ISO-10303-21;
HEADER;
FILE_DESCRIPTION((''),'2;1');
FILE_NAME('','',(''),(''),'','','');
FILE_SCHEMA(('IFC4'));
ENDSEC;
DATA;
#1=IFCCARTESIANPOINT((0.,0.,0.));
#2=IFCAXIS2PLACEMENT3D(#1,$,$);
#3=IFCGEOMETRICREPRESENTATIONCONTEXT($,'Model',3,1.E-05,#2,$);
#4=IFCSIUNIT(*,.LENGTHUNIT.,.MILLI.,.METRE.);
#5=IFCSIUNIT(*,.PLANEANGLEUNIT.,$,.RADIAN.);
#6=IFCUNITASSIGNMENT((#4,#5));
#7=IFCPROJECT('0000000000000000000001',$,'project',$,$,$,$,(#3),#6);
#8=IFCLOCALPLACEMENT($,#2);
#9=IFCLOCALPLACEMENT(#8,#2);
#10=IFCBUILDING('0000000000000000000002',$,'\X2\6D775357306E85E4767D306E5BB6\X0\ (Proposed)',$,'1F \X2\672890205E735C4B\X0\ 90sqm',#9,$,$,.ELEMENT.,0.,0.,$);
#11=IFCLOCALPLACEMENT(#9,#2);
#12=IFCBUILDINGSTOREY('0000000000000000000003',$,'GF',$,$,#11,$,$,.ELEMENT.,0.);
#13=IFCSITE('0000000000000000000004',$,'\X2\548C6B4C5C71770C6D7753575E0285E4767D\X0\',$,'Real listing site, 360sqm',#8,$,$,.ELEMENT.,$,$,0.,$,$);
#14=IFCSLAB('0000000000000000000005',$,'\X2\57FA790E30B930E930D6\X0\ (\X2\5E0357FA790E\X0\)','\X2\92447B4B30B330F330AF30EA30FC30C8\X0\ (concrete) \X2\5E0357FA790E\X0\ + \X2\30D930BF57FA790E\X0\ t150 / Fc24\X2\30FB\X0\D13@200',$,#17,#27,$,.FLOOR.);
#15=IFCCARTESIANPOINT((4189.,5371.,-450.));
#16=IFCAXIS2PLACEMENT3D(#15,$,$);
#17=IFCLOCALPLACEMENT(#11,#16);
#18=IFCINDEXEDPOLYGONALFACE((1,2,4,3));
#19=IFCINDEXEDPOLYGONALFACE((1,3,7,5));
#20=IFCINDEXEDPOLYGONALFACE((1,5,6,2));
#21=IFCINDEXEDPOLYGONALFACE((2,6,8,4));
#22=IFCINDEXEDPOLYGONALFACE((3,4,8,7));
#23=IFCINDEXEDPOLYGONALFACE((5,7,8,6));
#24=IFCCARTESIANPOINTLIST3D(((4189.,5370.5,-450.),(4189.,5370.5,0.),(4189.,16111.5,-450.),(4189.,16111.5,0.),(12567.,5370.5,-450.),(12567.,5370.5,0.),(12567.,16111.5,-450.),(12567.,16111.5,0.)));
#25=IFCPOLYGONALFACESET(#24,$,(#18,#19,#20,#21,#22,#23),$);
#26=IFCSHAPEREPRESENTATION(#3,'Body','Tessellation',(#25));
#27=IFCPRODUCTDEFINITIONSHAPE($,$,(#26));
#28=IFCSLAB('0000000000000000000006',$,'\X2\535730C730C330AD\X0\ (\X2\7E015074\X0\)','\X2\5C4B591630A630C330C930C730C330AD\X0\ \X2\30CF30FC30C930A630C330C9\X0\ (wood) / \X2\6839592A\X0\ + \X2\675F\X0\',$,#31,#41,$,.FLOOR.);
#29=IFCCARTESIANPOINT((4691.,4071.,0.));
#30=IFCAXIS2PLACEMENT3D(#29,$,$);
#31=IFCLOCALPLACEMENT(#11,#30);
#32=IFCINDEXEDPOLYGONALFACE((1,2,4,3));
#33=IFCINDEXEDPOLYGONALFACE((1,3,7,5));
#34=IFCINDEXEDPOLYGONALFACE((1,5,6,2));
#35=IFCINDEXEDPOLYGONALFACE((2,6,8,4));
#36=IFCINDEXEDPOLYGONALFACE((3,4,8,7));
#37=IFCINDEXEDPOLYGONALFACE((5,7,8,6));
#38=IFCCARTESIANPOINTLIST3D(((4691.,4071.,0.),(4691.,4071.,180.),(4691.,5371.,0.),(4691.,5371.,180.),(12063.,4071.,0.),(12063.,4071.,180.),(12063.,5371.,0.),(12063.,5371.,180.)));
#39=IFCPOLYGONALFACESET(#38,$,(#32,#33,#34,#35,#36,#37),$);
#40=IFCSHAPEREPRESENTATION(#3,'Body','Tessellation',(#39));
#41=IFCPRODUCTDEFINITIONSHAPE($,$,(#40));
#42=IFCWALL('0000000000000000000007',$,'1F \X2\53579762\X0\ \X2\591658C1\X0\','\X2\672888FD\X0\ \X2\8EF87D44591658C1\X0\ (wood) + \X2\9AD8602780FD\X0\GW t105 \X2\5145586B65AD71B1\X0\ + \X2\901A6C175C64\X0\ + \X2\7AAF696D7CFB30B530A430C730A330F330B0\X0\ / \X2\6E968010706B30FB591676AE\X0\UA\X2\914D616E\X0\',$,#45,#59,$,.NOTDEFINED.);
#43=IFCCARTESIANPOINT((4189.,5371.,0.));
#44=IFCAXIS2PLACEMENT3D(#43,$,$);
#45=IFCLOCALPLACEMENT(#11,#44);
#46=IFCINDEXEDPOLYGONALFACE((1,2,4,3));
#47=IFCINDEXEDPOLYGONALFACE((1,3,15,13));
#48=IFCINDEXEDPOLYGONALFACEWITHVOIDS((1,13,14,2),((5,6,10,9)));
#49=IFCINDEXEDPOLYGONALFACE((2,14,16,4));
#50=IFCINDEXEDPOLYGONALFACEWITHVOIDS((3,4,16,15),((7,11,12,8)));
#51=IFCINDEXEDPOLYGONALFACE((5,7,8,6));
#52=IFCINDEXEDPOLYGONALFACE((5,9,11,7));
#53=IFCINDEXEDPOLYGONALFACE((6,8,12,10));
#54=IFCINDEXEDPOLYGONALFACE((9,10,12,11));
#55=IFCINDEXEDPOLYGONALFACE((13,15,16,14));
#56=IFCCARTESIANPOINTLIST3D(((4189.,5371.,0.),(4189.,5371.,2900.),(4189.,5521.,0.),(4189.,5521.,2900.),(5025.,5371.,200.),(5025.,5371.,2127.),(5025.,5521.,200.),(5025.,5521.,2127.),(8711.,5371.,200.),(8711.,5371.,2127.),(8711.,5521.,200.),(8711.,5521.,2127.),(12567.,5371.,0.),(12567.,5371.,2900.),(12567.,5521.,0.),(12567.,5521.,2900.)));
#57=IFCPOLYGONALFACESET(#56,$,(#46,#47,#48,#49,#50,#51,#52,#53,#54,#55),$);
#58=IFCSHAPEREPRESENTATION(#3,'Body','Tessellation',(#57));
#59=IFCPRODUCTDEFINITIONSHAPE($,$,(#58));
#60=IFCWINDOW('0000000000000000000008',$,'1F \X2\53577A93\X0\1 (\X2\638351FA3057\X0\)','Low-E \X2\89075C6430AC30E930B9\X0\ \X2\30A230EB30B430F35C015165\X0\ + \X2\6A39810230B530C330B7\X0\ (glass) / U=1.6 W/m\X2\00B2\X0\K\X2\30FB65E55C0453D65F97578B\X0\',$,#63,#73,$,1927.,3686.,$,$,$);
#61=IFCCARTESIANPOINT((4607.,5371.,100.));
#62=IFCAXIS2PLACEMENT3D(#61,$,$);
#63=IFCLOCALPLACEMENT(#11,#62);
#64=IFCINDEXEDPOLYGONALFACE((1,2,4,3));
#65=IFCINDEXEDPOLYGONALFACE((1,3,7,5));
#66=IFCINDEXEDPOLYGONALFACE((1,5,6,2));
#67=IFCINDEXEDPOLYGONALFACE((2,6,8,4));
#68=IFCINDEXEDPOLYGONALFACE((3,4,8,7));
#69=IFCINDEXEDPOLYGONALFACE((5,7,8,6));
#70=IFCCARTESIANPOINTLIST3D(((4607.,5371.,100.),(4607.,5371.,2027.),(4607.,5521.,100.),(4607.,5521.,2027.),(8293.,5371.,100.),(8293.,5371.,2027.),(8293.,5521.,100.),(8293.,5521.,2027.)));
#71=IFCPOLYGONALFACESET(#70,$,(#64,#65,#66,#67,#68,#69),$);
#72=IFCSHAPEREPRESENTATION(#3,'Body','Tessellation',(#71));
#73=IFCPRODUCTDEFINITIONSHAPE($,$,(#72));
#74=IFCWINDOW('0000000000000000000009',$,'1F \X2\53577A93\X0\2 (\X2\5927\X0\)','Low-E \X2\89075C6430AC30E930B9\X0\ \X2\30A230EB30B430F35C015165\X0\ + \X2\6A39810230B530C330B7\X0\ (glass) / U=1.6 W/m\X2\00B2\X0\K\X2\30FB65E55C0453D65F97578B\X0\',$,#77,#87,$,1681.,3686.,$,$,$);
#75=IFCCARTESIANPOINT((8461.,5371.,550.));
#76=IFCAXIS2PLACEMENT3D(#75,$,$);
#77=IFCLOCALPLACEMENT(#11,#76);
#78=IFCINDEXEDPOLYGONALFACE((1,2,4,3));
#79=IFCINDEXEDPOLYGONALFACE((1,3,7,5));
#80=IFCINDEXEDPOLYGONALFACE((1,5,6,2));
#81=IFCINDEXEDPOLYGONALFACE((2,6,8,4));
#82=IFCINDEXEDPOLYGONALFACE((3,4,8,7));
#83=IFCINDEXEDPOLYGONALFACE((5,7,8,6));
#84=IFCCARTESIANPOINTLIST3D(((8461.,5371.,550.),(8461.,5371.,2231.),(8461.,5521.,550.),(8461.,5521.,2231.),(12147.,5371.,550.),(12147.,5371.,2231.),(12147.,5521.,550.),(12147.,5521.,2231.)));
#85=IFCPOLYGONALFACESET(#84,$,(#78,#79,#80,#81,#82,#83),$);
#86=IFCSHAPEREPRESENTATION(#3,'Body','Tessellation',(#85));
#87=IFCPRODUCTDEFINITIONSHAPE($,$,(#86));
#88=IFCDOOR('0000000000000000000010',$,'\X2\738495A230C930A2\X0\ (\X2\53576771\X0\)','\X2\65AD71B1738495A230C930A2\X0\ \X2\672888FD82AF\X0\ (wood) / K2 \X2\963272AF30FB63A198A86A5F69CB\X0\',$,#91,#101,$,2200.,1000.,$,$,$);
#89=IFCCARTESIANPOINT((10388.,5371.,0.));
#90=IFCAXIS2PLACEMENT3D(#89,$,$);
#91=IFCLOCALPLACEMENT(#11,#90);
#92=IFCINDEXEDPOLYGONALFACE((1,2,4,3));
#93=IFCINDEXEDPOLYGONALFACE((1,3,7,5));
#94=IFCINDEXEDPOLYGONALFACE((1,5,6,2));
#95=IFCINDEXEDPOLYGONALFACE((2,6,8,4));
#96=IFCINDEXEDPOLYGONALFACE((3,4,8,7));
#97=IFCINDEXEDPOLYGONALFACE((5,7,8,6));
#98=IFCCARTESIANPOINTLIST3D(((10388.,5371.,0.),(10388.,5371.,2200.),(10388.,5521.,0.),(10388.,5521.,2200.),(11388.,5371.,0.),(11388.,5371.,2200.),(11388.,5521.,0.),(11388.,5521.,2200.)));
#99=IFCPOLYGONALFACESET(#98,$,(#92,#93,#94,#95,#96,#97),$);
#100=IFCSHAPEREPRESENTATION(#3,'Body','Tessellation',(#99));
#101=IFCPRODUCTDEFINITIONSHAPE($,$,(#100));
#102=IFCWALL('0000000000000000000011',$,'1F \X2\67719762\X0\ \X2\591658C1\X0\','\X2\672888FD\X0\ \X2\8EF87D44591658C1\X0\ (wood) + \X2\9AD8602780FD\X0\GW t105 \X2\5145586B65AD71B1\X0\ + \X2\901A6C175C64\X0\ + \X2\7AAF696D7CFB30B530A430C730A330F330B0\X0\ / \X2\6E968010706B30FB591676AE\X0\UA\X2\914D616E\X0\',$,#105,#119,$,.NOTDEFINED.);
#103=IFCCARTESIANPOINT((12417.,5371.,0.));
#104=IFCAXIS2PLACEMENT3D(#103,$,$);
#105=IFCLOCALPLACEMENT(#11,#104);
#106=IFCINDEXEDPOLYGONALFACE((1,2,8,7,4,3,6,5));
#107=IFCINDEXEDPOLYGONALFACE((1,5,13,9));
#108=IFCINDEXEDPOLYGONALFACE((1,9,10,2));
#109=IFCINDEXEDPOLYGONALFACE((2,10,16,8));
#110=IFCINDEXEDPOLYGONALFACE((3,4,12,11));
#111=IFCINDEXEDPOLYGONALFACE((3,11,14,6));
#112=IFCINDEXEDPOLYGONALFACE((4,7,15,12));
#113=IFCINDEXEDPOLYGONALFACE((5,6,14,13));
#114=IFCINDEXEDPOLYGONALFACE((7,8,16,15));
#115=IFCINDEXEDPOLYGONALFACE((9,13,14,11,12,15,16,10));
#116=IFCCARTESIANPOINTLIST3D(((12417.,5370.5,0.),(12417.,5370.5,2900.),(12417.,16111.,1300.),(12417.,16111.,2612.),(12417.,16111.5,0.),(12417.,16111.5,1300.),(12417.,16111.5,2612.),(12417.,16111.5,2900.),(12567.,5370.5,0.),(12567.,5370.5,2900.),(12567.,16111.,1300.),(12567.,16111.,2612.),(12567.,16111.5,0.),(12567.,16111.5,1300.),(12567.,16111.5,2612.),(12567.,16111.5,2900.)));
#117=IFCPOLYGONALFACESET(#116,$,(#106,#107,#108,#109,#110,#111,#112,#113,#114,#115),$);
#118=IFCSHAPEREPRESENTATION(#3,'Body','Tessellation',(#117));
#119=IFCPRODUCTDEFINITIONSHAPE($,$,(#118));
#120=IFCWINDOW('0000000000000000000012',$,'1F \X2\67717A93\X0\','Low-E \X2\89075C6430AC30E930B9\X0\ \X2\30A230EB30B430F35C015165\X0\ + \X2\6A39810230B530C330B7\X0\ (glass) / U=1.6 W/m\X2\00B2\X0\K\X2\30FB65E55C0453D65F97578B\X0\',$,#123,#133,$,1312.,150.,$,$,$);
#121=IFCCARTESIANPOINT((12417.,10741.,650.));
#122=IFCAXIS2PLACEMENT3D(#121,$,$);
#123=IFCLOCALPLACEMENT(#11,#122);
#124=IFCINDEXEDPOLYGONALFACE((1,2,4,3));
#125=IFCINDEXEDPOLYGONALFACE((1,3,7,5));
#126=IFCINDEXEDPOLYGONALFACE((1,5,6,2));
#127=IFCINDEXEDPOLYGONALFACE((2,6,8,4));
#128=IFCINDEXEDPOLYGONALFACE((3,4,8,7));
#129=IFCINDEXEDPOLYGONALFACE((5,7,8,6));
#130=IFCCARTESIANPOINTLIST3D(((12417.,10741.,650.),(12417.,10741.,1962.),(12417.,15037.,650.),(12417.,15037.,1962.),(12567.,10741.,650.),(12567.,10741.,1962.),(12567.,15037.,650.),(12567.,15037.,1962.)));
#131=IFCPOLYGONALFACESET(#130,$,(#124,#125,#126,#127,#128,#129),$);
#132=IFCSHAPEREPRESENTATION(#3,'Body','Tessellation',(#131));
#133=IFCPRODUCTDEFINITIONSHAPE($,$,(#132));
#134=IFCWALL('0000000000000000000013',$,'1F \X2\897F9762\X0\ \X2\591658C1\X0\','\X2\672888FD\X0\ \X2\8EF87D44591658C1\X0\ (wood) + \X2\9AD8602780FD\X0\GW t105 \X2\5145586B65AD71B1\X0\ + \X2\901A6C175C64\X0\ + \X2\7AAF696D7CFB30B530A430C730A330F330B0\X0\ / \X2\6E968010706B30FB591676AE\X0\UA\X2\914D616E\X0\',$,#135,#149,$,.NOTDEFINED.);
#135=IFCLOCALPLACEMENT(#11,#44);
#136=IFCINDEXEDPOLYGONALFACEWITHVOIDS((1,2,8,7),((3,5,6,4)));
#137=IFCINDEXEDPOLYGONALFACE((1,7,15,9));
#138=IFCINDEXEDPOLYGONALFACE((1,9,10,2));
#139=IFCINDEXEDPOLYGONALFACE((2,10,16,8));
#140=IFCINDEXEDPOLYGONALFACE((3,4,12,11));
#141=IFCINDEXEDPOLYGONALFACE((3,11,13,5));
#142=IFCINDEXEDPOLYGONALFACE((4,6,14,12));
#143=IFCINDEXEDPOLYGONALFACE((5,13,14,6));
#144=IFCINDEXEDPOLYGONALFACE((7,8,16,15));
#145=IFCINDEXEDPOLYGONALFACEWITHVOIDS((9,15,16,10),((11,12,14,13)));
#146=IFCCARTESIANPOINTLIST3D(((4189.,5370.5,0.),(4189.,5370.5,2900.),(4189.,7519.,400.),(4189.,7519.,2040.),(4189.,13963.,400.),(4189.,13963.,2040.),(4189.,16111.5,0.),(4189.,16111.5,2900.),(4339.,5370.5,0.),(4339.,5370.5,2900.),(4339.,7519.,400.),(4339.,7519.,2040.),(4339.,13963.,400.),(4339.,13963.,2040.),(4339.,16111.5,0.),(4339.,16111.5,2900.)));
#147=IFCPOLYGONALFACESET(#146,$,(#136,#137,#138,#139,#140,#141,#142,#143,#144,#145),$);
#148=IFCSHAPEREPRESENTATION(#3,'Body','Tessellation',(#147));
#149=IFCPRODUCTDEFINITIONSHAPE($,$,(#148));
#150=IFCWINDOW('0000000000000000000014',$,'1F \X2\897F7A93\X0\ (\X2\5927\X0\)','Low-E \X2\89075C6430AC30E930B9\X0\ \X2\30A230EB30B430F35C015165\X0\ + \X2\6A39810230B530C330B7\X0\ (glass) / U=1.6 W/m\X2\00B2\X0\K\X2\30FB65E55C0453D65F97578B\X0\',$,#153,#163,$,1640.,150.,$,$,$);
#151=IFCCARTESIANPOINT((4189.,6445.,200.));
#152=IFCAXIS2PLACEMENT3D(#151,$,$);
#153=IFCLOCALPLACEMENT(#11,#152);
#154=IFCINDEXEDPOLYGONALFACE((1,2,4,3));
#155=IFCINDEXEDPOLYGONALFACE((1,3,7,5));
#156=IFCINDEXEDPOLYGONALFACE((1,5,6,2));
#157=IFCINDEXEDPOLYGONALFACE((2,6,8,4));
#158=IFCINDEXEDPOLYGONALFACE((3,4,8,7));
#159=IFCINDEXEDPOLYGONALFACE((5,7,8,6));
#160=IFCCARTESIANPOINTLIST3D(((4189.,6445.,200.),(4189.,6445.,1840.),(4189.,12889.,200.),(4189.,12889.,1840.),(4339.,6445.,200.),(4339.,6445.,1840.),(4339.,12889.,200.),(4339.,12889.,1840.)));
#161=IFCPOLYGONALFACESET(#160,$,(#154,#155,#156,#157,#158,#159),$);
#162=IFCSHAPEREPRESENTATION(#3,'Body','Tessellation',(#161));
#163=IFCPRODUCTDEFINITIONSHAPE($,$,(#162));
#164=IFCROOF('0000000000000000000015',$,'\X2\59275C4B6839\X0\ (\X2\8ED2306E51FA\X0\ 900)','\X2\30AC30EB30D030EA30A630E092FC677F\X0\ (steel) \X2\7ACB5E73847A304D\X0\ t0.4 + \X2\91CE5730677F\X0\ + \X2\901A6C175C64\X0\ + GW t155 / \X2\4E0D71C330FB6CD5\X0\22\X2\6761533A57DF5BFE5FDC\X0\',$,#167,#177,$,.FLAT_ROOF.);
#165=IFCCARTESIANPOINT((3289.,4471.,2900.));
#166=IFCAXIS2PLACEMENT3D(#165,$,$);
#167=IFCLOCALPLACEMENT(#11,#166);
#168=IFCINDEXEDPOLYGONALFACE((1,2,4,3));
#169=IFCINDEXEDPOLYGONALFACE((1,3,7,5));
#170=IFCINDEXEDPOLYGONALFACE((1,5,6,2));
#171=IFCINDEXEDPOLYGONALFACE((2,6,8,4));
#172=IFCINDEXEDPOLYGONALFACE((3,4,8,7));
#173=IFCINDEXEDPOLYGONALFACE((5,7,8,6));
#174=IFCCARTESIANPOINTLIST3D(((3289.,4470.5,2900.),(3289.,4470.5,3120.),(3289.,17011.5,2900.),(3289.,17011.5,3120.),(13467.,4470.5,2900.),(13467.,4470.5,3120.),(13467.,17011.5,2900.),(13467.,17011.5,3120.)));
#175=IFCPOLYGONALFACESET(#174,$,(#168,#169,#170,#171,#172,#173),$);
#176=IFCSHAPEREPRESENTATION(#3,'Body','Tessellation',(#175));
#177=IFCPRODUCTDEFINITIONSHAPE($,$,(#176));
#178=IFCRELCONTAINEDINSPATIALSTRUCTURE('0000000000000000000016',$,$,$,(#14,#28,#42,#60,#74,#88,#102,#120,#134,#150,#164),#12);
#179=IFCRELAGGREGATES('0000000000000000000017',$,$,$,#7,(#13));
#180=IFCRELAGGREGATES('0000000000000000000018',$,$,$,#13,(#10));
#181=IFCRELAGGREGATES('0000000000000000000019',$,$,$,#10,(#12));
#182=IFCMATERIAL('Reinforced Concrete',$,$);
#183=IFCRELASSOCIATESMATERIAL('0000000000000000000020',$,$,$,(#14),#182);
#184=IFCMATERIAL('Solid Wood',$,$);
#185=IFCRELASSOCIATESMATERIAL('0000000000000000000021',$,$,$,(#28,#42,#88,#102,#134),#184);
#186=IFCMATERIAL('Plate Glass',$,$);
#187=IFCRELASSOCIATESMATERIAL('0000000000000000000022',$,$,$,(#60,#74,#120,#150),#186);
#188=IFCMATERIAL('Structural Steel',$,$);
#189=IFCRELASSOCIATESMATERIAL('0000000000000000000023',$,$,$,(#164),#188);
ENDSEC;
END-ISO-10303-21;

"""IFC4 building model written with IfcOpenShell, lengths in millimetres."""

from ifc_helpers import new_model, si_unit, frame, frame_2d, origin, place, context, project, spatial, rectangle, extrude, material, element, fill, save


model = new_model("IFC4")

# Units and contexts
model_context = context("Model", 3, precision=1e-05, world=origin())
ifc_project = project(units=[si_unit("LENGTHUNIT", "METRE", prefix="MILLI"), si_unit("PLANEANGLEUNIT", "RADIAN")], contexts=[model_context])

# Site, building, storey
site_placement = place(None, origin())
site = spatial("IfcSite", under=ifc_project, at=site_placement, Name="和歌山県海南市藤白", ObjectType="Real listing site, 360sqm", CompositionType="ELEMENT", RefElevation=0.0)
building_placement = place(site_placement, origin())
building = spatial("IfcBuilding", under=site, at=building_placement, Name="海南の藤白の家 (Proposed)", ObjectType="1F 木造平屋 90sqm", CompositionType="ELEMENT", ElevationOfRefHeight=0.0, ElevationOfTerrain=0.0)
storey_placement = place(building_placement, origin())
storey = spatial("IfcBuildingStorey", under=building, at=storey_placement, Name="GF", CompositionType="ELEMENT", Elevation=0.0)

# Slabs
ifc_material_1 = material(Name="Reinforced Concrete")
slab_1_placement = place(storey_placement, frame((4189.0, 5371.0, -450.0)))
element("IfcSlab", 1, at=slab_1_placement, inside=storey, material=ifc_material_1, Name="基礎スラブ (布基礎)", Description="鉄筋コンクリート (concrete) 布基礎 + ベタ基礎 t150 / Fc24・D13@200", PredefinedType="FLOOR", context=model_context, shape_type="SweptSolid", body=[
    extrude(rectangle(XDim=8378.0, YDim=10741.0, at=frame_2d((4189.0, 5370.0))), frame((4189.0, 5371.0, -450.0)), (0.0, 0.0, 1.0), 450.0),
])
ifc_material_2 = material(Name="Solid Wood")
slab_2_placement = place(storey_placement, frame((4691.0, 4071.0, 0.0)))
element("IfcSlab", 2, at=slab_2_placement, inside=storey, material=ifc_material_2, Name="南デッキ (縁側)", Description="屋外ウッドデッキ ハードウッド (wood) / 根太 + 束", PredefinedType="FLOOR", context=model_context, shape_type="SweptSolid", body=[
    extrude(rectangle(XDim=7372.0, YDim=1300.0, at=frame_2d((3686.0, 650.0))), frame((4691.0, 4071.0, 0.0)), (0.0, 0.0, 1.0), 180.0),
])

# Wall, openings, windows, door
wall_1_placement = place(storey_placement, frame((4189.0, 5371.0, 0.0)))
wall_1 = element("IfcWall", 3, at=wall_1_placement, inside=storey, material=ifc_material_2, Name="1F 南面 外壁", Description="木製 軸組外壁 (wood) + 高性能GW t105 充填断熱 + 通気層 + 窯業系サイディング / 準耐火・外皮UA配慮", PredefinedType="NOTDEFINED", context=model_context, shape_type="SweptSolid", body=[
    extrude(rectangle(XDim=8378.0, YDim=150.0, at=frame_2d((4189.0, 75.0))), frame((4189.0, 5371.0, 0.0)), (0.0, 0.0, 1.0), 2900.0),
])
opening_1_placement = place(storey_placement, frame((4607.0, 5371.0, 100.0)))
opening_1 = element("IfcOpeningElement", 4, at=opening_1_placement, cuts=wall_1, PredefinedType="NOTDEFINED", context=model_context, shape_type="SweptSolid", body=[
    extrude(rectangle(XDim=3686.0, YDim=150.0, at=frame_2d((1843.0, 75.0))), frame((4607.0, 5371.0, 100.0)), (0.0, 0.0, 1.0), 1927.0),
])
opening_2_placement = place(storey_placement, frame((8461.0, 5371.0, 550.0)))
opening_2 = element("IfcOpeningElement", 5, at=opening_2_placement, cuts=wall_1, PredefinedType="NOTDEFINED", context=model_context, shape_type="SweptSolid", body=[
    extrude(rectangle(XDim=3686.0, YDim=150.0, at=frame_2d((1843.0, 75.0))), frame((8461.0, 5371.0, 550.0)), (0.0, 0.0, 1.0), 1681.0),
])
opening_3_placement = place(storey_placement, frame((10388.0, 5371.0, 0.0)))
opening_3 = element("IfcOpeningElement", 6, at=opening_3_placement, cuts=wall_1, PredefinedType="NOTDEFINED", context=model_context, shape_type="SweptSolid", body=[
    extrude(rectangle(XDim=1000.0, YDim=150.0, at=frame_2d((500.0, 75.0))), frame((10388.0, 5371.0, 0.0)), (0.0, 0.0, 1.0), 2200.0),
])
ifc_material_3 = material(Name="Plate Glass")
window_1_placement = place(storey_placement, frame((4607.0, 5371.0, 100.0)))
window_1 = element("IfcWindow", 7, at=window_1_placement, inside=storey, material=ifc_material_3, Name="1F 南窓1 (掃出し)", Description="Low-E 複層ガラス アルゴン封入 + 樹脂サッシ (glass) / U=1.6 W/m²K・日射取得型", OverallHeight=1927.0, OverallWidth=3686.0, context=model_context, shape_type="SweptSolid", body=[
    extrude(rectangle(XDim=3686.0, YDim=150.0, at=frame_2d((1843.0, 75.0))), frame((4607.0, 5371.0, 100.0)), (0.0, 0.0, 1.0), 1927.0),
])
fill(opening_1, window_1)
window_2_placement = place(storey_placement, frame((8461.0, 5371.0, 550.0)))
window_2 = element("IfcWindow", 8, at=window_2_placement, inside=storey, material=ifc_material_3, Name="1F 南窓2 (大)", Description="Low-E 複層ガラス アルゴン封入 + 樹脂サッシ (glass) / U=1.6 W/m²K・日射取得型", OverallHeight=1681.0, OverallWidth=3686.0, context=model_context, shape_type="SweptSolid", body=[
    extrude(rectangle(XDim=3686.0, YDim=150.0, at=frame_2d((1843.0, 75.0))), frame((8461.0, 5371.0, 550.0)), (0.0, 0.0, 1.0), 1681.0),
])
fill(opening_2, window_2)
door_placement = place(storey_placement, frame((10388.0, 5371.0, 0.0)))
door = element("IfcDoor", 9, at=door_placement, inside=storey, material=ifc_material_2, Name="玄関ドア (南東)", Description="断熱玄関ドア 木製芯 (wood) / K2 防犯・採風機構", OverallHeight=2200.0, OverallWidth=1000.0, context=model_context, shape_type="SweptSolid", body=[
    extrude(rectangle(XDim=1000.0, YDim=150.0, at=frame_2d((500.0, 75.0))), frame((10388.0, 5371.0, 0.0)), (0.0, 0.0, 1.0), 2200.0),
])
fill(opening_3, door)

# Walls, openings, windows
wall_2_placement = place(storey_placement, frame((12417.0, 5371.0, 0.0)))
wall_2 = element("IfcWall", 10, at=wall_2_placement, inside=storey, material=ifc_material_2, Name="1F 東面 外壁", Description="木製 軸組外壁 (wood) + 高性能GW t105 充填断熱 + 通気層 + 窯業系サイディング / 準耐火・外皮UA配慮", PredefinedType="NOTDEFINED", context=model_context, shape_type="SweptSolid", body=[
    extrude(rectangle(XDim=150.0, YDim=10741.0, at=frame_2d((75.0, 5370.0))), frame((12417.0, 5371.0, 0.0)), (0.0, 0.0, 1.0), 2900.0),
])
opening_4_placement = place(storey_placement, frame((12417.0, 10741.0, 650.0)))
opening_4 = element("IfcOpeningElement", 11, at=opening_4_placement, cuts=wall_2, PredefinedType="NOTDEFINED", context=model_context, shape_type="SweptSolid", body=[
    extrude(rectangle(XDim=150.0, YDim=4296.0, at=frame_2d((75.0, 2148.0))), frame((12417.0, 10741.0, 650.0)), (0.0, 0.0, 1.0), 1312.0),
])
window_3_placement = place(storey_placement, frame((12417.0, 10741.0, 650.0)))
window_3 = element("IfcWindow", 12, at=window_3_placement, inside=storey, material=ifc_material_3, Name="1F 東窓", Description="Low-E 複層ガラス アルゴン封入 + 樹脂サッシ (glass) / U=1.6 W/m²K・日射取得型", OverallHeight=1312.0, OverallWidth=150.0, context=model_context, shape_type="SweptSolid", body=[
    extrude(rectangle(XDim=150.0, YDim=4296.0, at=frame_2d((75.0, 2148.0))), frame((12417.0, 10741.0, 650.0)), (0.0, 0.0, 1.0), 1312.0),
])
fill(opening_4, window_3)
wall_3_placement = place(storey_placement, frame((4189.0, 5371.0, 0.0)))
wall_3 = element("IfcWall", 13, at=wall_3_placement, inside=storey, material=ifc_material_2, Name="1F 西面 外壁", Description="木製 軸組外壁 (wood) + 高性能GW t105 充填断熱 + 通気層 + 窯業系サイディング / 準耐火・外皮UA配慮", PredefinedType="NOTDEFINED", context=model_context, shape_type="SweptSolid", body=[
    extrude(rectangle(XDim=150.0, YDim=10741.0, at=frame_2d((75.0, 5370.0))), frame((4189.0, 5371.0, 0.0)), (0.0, 0.0, 1.0), 2900.0),
])
opening_5_placement = place(storey_placement, frame((4189.0, 6445.0, 200.0)))
opening_5 = element("IfcOpeningElement", 14, at=opening_5_placement, cuts=wall_3, PredefinedType="NOTDEFINED", context=model_context, shape_type="SweptSolid", body=[
    extrude(rectangle(XDim=150.0, YDim=6444.0, at=frame_2d((75.0, 3222.0))), frame((4189.0, 6445.0, 200.0)), (0.0, 0.0, 1.0), 1640.0),
])
window_4_placement = place(storey_placement, frame((4189.0, 6445.0, 200.0)))
window_4 = element("IfcWindow", 15, at=window_4_placement, inside=storey, material=ifc_material_3, Name="1F 西窓 (大)", Description="Low-E 複層ガラス アルゴン封入 + 樹脂サッシ (glass) / U=1.6 W/m²K・日射取得型", OverallHeight=1640.0, OverallWidth=150.0, context=model_context, shape_type="SweptSolid", body=[
    extrude(rectangle(XDim=150.0, YDim=6444.0, at=frame_2d((75.0, 3222.0))), frame((4189.0, 6445.0, 200.0)), (0.0, 0.0, 1.0), 1640.0),
])
fill(opening_5, window_4)

# Roof
ifc_material_4 = material(Name="Structural Steel")
roof_placement = place(storey_placement, frame((3289.0, 4471.0, 2900.0)))
element("IfcRoof", 16, at=roof_placement, inside=storey, material=ifc_material_4, Name="大屋根 (軒の出 900)", Description="ガルバリウム鋼板 (steel) 立平葺き t0.4 + 野地板 + 通気層 + GW t155 / 不燃・法22条区域対応", PredefinedType="FLAT_ROOF", context=model_context, shape_type="SweptSolid", body=[
    extrude(rectangle(XDim=10178.0, YDim=12541.0, at=frame_2d((5089.0, 6270.0))), frame((3289.0, 4471.0, 2900.0)), (0.0, 0.0, 1.0), 220.0),
])

save(model, "model.ifc")
